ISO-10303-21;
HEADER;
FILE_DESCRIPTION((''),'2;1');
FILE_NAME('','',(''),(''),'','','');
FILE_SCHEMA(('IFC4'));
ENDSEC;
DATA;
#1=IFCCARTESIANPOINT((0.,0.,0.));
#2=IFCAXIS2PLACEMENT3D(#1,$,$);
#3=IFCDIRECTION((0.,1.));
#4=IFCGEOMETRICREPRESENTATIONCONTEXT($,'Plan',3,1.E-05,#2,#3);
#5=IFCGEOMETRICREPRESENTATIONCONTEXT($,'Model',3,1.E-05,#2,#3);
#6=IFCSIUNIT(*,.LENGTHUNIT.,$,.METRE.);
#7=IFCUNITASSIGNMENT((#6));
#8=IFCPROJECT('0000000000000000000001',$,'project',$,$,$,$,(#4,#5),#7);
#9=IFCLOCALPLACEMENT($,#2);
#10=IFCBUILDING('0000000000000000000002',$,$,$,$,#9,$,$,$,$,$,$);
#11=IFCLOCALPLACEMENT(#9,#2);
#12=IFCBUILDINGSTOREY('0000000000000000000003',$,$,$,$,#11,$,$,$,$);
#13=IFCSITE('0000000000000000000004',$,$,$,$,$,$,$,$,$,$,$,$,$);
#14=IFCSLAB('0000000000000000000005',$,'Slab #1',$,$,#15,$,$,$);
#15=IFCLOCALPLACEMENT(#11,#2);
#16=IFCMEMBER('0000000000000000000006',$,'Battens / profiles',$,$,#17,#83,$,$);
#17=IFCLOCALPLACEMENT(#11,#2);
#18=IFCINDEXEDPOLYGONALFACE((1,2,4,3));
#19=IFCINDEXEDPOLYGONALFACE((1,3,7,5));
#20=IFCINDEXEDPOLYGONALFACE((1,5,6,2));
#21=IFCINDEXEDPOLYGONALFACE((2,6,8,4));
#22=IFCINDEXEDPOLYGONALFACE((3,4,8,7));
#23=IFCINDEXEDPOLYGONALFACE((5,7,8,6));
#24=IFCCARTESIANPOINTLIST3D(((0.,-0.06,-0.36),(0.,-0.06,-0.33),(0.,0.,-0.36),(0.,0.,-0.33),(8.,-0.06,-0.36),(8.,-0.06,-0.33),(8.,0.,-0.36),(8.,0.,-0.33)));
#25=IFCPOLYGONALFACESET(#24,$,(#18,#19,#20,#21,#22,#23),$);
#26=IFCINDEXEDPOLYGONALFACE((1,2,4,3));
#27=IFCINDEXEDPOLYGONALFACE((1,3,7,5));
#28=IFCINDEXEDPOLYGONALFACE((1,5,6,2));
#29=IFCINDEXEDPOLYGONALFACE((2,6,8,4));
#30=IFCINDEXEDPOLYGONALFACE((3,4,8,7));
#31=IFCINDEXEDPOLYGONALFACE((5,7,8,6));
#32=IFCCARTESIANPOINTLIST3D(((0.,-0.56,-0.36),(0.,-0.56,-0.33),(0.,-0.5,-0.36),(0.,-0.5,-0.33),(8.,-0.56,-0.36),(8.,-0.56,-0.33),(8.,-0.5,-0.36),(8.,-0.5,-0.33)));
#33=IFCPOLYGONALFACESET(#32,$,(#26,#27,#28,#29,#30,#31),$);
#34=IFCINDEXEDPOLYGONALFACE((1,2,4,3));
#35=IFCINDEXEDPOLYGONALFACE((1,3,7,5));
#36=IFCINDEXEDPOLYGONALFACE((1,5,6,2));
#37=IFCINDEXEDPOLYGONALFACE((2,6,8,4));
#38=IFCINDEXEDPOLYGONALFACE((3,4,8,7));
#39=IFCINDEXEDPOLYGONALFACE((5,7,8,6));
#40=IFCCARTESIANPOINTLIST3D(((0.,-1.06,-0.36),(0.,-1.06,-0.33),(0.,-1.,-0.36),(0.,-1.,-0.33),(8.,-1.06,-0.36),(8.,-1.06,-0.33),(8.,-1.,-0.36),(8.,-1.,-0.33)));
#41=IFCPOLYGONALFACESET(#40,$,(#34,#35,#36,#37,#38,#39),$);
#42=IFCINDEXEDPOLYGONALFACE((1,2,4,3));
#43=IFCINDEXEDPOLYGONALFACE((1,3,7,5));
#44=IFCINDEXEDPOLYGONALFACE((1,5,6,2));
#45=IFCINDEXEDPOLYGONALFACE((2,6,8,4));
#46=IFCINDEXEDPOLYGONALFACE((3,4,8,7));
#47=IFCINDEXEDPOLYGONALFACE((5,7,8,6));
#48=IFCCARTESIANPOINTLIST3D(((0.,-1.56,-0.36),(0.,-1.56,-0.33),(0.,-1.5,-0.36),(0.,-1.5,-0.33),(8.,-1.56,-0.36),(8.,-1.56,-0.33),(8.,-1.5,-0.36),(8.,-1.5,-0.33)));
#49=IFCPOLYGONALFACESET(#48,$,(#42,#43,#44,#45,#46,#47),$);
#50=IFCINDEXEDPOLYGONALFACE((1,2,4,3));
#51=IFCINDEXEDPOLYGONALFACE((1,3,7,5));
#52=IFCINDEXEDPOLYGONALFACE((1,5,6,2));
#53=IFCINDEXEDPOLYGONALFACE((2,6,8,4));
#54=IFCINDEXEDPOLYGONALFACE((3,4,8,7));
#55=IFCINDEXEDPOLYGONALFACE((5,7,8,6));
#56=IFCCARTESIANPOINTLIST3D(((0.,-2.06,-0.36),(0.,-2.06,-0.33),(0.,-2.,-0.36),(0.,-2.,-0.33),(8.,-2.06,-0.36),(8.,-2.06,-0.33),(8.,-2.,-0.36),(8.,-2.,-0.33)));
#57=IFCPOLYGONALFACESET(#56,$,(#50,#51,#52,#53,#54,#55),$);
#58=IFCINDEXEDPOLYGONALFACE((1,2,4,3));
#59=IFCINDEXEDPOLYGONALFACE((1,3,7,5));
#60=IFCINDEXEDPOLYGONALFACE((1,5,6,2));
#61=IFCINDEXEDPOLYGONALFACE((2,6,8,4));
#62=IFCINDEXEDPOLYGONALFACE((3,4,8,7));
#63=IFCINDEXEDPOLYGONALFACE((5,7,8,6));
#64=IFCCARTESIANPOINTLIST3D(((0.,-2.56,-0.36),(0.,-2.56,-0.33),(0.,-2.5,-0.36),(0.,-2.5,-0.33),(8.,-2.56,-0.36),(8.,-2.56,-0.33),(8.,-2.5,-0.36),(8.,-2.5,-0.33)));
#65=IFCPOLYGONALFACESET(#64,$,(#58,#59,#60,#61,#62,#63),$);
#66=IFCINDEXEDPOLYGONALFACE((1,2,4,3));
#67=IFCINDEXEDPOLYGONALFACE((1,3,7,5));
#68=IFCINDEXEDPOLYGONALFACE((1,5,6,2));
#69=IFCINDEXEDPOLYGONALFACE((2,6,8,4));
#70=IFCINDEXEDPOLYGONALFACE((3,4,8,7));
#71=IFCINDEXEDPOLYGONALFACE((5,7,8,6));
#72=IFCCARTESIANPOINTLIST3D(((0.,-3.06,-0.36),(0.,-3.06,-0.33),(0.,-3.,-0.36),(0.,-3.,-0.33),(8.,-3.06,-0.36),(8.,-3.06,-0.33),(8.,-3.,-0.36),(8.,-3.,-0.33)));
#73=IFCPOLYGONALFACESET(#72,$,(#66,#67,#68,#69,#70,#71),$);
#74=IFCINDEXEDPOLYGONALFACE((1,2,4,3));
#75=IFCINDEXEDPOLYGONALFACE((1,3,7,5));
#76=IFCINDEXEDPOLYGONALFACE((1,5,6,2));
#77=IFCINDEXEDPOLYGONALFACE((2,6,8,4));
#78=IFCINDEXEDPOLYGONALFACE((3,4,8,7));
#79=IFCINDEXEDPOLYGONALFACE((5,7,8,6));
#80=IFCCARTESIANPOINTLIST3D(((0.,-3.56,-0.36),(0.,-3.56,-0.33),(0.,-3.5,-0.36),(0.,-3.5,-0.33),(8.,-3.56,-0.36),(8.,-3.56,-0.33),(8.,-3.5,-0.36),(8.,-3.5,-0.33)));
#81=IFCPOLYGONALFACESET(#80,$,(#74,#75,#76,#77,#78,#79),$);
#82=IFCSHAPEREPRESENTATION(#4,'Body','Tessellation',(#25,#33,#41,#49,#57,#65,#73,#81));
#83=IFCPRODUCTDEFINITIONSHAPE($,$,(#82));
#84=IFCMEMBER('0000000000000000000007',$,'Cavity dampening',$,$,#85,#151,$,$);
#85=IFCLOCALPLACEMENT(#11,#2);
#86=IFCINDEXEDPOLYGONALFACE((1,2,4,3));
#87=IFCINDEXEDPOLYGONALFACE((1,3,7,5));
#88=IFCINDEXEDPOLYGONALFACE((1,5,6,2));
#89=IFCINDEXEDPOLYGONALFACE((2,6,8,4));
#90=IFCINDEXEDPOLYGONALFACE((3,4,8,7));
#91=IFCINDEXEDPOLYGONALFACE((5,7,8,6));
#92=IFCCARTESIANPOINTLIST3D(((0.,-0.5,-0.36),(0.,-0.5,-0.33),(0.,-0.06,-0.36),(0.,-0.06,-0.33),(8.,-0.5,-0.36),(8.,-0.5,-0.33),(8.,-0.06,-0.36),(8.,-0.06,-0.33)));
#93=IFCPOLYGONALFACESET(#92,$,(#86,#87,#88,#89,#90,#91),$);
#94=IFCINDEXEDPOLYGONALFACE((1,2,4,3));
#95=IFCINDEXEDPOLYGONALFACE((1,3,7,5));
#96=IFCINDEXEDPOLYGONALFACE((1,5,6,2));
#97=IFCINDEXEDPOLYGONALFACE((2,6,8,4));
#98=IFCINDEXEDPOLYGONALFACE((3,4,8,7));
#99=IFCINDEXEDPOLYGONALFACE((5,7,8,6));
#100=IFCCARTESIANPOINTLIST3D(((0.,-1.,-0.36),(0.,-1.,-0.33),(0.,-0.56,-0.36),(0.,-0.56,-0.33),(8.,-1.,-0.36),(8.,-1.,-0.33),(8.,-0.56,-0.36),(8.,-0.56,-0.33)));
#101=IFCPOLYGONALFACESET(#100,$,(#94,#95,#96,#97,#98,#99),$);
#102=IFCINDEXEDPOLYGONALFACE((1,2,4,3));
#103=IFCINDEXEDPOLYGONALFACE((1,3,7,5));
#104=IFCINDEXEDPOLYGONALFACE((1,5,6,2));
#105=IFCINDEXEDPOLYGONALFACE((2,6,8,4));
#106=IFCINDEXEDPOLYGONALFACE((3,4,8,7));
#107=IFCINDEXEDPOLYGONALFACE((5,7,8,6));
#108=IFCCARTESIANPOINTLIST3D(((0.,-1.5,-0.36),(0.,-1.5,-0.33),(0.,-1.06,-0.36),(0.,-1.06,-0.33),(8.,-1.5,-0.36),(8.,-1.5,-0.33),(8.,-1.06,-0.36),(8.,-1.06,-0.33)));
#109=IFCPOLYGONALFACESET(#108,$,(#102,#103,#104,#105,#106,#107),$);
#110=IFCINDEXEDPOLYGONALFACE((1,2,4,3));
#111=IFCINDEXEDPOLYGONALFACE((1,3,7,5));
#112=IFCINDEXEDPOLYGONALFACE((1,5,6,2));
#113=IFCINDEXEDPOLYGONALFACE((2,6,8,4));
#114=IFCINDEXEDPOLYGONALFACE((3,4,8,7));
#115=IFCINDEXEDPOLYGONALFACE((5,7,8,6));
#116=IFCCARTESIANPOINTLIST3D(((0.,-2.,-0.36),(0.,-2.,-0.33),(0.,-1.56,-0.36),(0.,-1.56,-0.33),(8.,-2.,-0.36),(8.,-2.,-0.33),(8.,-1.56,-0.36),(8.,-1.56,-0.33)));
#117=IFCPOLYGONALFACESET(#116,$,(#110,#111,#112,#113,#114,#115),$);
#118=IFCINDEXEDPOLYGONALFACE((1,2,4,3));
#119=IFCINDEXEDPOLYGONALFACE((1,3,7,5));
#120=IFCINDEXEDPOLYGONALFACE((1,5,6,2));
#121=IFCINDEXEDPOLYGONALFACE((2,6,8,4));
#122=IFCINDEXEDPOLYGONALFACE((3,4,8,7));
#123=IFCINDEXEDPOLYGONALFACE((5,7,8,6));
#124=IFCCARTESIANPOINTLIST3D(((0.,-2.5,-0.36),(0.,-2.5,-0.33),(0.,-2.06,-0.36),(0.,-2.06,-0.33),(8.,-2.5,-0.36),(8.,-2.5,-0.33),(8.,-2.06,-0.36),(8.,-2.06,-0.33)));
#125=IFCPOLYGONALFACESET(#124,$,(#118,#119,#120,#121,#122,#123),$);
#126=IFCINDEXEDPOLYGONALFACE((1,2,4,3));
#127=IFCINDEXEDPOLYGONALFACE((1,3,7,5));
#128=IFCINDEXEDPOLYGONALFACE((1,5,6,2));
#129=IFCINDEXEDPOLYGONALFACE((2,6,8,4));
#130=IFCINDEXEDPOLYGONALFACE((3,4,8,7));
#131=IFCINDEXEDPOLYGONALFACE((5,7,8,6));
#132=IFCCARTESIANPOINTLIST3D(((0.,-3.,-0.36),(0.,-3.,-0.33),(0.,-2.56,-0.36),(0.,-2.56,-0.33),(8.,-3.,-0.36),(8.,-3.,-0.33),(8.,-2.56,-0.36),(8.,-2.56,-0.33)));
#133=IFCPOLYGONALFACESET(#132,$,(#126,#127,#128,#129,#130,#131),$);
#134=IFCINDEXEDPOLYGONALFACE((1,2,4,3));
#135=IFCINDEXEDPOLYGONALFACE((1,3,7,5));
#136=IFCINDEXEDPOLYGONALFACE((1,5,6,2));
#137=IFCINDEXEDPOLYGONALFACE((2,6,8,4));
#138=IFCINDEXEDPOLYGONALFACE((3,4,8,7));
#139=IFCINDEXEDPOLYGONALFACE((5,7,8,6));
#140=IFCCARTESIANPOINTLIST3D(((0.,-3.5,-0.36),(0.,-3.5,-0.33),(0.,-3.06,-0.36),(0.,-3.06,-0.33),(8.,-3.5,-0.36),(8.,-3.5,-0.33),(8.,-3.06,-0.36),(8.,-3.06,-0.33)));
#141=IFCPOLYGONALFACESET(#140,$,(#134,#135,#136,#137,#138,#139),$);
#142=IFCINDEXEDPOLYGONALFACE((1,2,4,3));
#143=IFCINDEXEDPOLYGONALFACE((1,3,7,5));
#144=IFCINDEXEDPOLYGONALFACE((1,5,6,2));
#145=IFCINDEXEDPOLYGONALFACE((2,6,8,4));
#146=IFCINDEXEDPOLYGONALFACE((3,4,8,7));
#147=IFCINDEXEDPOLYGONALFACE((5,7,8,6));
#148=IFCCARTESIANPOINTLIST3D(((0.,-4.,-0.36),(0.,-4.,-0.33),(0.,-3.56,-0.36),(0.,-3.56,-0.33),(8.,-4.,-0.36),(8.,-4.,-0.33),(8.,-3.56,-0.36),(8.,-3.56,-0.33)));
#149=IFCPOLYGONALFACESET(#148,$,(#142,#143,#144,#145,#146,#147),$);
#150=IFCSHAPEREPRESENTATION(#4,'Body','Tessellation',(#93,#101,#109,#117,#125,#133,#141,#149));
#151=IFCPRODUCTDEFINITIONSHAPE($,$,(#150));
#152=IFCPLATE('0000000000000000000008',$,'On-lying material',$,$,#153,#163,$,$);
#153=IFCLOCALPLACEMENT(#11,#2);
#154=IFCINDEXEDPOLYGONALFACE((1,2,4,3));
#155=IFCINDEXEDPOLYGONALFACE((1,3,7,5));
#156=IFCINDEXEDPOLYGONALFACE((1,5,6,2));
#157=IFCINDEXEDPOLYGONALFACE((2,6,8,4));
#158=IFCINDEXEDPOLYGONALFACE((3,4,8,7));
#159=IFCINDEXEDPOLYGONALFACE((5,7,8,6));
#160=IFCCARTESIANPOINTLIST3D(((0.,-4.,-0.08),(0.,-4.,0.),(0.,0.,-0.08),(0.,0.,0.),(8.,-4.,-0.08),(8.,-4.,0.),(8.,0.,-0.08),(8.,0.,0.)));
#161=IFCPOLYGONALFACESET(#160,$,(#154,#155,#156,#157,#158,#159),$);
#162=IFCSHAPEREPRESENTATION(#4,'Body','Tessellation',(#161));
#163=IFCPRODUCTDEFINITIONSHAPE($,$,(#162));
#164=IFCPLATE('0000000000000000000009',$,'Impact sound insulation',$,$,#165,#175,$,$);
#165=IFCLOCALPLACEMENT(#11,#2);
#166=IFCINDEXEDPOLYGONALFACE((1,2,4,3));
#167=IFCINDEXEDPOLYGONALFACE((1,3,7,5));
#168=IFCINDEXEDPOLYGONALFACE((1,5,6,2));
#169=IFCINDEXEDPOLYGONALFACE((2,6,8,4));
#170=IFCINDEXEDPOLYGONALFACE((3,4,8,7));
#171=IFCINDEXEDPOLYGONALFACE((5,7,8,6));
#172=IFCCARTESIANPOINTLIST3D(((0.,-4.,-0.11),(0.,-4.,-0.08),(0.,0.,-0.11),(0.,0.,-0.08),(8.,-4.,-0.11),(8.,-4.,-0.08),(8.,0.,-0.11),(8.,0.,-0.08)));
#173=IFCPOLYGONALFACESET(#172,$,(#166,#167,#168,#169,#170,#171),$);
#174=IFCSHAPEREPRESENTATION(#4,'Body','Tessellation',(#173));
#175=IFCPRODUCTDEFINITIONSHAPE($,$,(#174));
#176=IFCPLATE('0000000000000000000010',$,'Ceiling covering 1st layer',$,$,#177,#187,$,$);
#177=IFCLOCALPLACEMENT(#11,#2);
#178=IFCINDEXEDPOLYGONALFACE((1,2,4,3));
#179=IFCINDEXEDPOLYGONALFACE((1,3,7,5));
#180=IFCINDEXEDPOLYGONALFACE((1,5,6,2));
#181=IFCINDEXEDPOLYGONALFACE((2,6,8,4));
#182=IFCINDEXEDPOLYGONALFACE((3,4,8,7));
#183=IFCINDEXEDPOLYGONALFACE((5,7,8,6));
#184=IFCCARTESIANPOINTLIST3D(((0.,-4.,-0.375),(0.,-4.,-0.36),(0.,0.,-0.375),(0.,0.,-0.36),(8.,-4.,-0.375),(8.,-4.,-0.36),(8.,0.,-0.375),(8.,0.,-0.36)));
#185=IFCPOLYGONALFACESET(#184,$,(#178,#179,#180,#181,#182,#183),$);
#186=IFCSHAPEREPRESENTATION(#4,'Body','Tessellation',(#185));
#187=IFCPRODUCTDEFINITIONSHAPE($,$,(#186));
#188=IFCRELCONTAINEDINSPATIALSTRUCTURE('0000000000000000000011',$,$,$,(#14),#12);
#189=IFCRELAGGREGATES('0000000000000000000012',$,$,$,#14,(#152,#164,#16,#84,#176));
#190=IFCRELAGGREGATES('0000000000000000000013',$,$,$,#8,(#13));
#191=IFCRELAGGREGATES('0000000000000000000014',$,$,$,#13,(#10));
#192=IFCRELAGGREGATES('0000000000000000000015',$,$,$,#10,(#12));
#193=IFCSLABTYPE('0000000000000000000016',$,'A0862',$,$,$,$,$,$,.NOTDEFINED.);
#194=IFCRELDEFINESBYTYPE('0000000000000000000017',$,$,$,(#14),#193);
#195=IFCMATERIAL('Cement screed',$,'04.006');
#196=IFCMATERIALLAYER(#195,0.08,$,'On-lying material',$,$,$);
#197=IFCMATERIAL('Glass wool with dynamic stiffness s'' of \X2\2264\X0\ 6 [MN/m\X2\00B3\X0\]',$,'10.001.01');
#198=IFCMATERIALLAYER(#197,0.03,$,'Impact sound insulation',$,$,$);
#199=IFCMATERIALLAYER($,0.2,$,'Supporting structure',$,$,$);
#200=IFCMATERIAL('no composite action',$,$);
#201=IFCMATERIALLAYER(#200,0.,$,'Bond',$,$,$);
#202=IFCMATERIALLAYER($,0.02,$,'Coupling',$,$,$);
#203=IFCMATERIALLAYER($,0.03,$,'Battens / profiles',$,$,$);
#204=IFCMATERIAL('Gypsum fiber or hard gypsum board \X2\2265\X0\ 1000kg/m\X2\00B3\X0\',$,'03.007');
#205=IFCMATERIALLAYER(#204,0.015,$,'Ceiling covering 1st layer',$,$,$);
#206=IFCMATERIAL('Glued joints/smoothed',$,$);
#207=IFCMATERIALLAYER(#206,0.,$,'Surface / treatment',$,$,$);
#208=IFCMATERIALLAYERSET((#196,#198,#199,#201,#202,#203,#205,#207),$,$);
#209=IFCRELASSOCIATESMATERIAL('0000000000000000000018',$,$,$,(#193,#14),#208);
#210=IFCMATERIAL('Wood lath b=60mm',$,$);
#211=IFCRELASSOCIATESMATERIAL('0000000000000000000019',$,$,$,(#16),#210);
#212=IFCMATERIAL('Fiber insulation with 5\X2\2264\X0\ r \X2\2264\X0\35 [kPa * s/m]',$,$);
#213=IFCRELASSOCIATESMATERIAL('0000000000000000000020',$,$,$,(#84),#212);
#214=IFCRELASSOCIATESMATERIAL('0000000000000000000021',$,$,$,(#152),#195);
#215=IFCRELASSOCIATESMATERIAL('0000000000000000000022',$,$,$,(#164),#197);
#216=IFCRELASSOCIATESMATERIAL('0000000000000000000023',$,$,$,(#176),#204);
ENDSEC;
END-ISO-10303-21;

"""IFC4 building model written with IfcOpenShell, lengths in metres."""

from ifc_helpers import new_model, si_unit, direction, frame, frame_2d, origin, origin_with_axes, place, context, project, spatial, rectangle, extrude, material, layer, layer_set, type_object, element, aggregate, save


model = new_model("IFC4")

# Units and contexts
plan_context = context("Plan", 3, precision=1e-05, world=origin(), true_north=direction((0.0, 1.0)))
model_context = context("Model", 3, precision=1e-05, world=origin(), true_north=direction((0.0, 1.0)))
ifc_project = project(units=[si_unit("LENGTHUNIT", "METRE")], contexts=[plan_context, model_context])

# Site, building, storey
site = spatial("IfcSite", under=ifc_project)
building_placement = place(None, origin())
building = spatial("IfcBuilding", under=site, at=building_placement)
storey_placement = place(building_placement, origin())
storey = spatial("IfcBuildingStorey", under=building, at=storey_placement)

# Slab, members, plates
ifc_material_1 = material(Name="Cement screed", Category="04.006")
ifc_layer_1 = layer(ifc_material_1, 0.08, Name="On-lying material")
ifc_material_2 = material(Name="Glass wool with dynamic stiffness s' of ≤ 6 [MN/m³]", Category="10.001.01")
ifc_layer_2 = layer(ifc_material_2, 0.03, Name="Impact sound insulation")
ifc_layer_3 = layer(None, 0.2, Name="Supporting structure")
ifc_material_3 = material(Name="no composite action")
ifc_layer_4 = layer(ifc_material_3, 0.0, Name="Bond")
ifc_layer_5 = layer(None, 0.02, Name="Coupling")
ifc_layer_6 = layer(None, 0.03, Name="Battens / profiles")
ifc_material_4 = material(Name="Gypsum fiber or hard gypsum board ≥ 1000kg/m³", Category="03.007")
ifc_layer_7 = layer(ifc_material_4, 0.015, Name="Ceiling covering 1st layer")
ifc_material_5 = material(Name="Glued joints/smoothed")
ifc_layer_8 = layer(ifc_material_5, 0.0, Name="Surface / treatment")
ifc_layer_set = layer_set([ifc_layer_1, ifc_layer_2, ifc_layer_3, ifc_layer_4, ifc_layer_5, ifc_layer_6, ifc_layer_7, ifc_layer_8])
slab_type = type_object("IfcSlabType", Name="A0862", PredefinedType="NOTDEFINED", material=ifc_layer_set)
slab_placement = place(None, frame((0.0, 0.0, 0.0), z_axis=(0.0, 0.0, -1.0), x_axis=(1.0, 0.0, 0.0)))
slab = element("IfcSlab", 1, at=slab_placement, inside=storey, type_object=slab_type, material=ifc_layer_set, Name="Slab #1")
ifc_material_6 = material(Name="Wood lath b=60mm")
member_1_placement = place(slab_placement, origin())
member_1 = element("IfcMember", 2, at=member_1_placement, material=ifc_material_6, Name="Battens / profiles", context=plan_context, shape_type="SweptSolid", body=[
    extrude(rectangle(XDim=0.06, YDim=0.03, at=frame_2d((0.03, 0.015), x_axis=(1.0, 0.0))), frame((0.0, 0.0, 0.33), z_axis=(1.0, 0.0, 0.0), x_axis=(0.0, 1.0, 0.0)), (0.0, 0.0, 1.0), 8.0),
    extrude(rectangle(XDim=0.06, YDim=0.03, at=frame_2d((0.03, 0.015), x_axis=(1.0, 0.0))), frame((0.0, 0.5, 0.33), z_axis=(1.0, 0.0, 0.0), x_axis=(0.0, 1.0, 0.0)), (0.0, 0.0, 1.0), 8.0),
    extrude(rectangle(XDim=0.06, YDim=0.03, at=frame_2d((0.03, 0.015), x_axis=(1.0, 0.0))), frame((0.0, 1.0, 0.33), z_axis=(1.0, 0.0, 0.0), x_axis=(0.0, 1.0, 0.0)), (0.0, 0.0, 1.0), 8.0),
    extrude(rectangle(XDim=0.06, YDim=0.03, at=frame_2d((0.03, 0.015), x_axis=(1.0, 0.0))), frame((0.0, 1.5, 0.33), z_axis=(1.0, 0.0, 0.0), x_axis=(0.0, 1.0, 0.0)), (0.0, 0.0, 1.0), 8.0),
    extrude(rectangle(XDim=0.06, YDim=0.03, at=frame_2d((0.03, 0.015), x_axis=(1.0, 0.0))), frame((0.0, 2.0, 0.33), z_axis=(1.0, 0.0, 0.0), x_axis=(0.0, 1.0, 0.0)), (0.0, 0.0, 1.0), 8.0),
    extrude(rectangle(XDim=0.06, YDim=0.03, at=frame_2d((0.03, 0.015), x_axis=(1.0, 0.0))), frame((0.0, 2.5, 0.33), z_axis=(1.0, 0.0, 0.0), x_axis=(0.0, 1.0, 0.0)), (0.0, 0.0, 1.0), 8.0),
    extrude(rectangle(XDim=0.06, YDim=0.03, at=frame_2d((0.03, 0.015), x_axis=(1.0, 0.0))), frame((0.0, 3.0, 0.33), z_axis=(1.0, 0.0, 0.0), x_axis=(0.0, 1.0, 0.0)), (0.0, 0.0, 1.0), 8.0),
    extrude(rectangle(XDim=0.06, YDim=0.03, at=frame_2d((0.03, 0.015), x_axis=(1.0, 0.0))), frame((0.0, 3.5, 0.33), z_axis=(1.0, 0.0, 0.0), x_axis=(0.0, 1.0, 0.0)), (0.0, 0.0, 1.0), 8.0),
])
ifc_material_7 = material(Name="Fiber insulation with 5≤ r ≤35 [kPa * s/m]")
member_2_placement = place(slab_placement, origin())
member_2 = element("IfcMember", 3, at=member_2_placement, material=ifc_material_7, Name="Cavity dampening", context=plan_context, shape_type="SweptSolid", body=[
    extrude(rectangle(XDim=0.44, YDim=0.03, at=frame_2d((0.22, 0.015), x_axis=(1.0, 0.0))), frame((0.0, 0.06, 0.33), z_axis=(1.0, 0.0, 0.0), x_axis=(0.0, 1.0, 0.0)), (0.0, 0.0, 1.0), 8.0),
    extrude(rectangle(XDim=0.44, YDim=0.03, at=frame_2d((0.22, 0.015), x_axis=(1.0, 0.0))), frame((0.0, 0.56, 0.33), z_axis=(1.0, 0.0, 0.0), x_axis=(0.0, 1.0, 0.0)), (0.0, 0.0, 1.0), 8.0),
    extrude(rectangle(XDim=0.44, YDim=0.03, at=frame_2d((0.22, 0.015), x_axis=(1.0, 0.0))), frame((0.0, 1.06, 0.33), z_axis=(1.0, 0.0, 0.0), x_axis=(0.0, 1.0, 0.0)), (0.0, 0.0, 1.0), 8.0),
    extrude(rectangle(XDim=0.44, YDim=0.03, at=frame_2d((0.22, 0.015), x_axis=(1.0, 0.0))), frame((0.0, 1.56, 0.33), z_axis=(1.0, 0.0, 0.0), x_axis=(0.0, 1.0, 0.0)), (0.0, 0.0, 1.0), 8.0),
    extrude(rectangle(XDim=0.44, YDim=0.03, at=frame_2d((0.22, 0.015), x_axis=(1.0, 0.0))), frame((0.0, 2.06, 0.33), z_axis=(1.0, 0.0, 0.0), x_axis=(0.0, 1.0, 0.0)), (0.0, 0.0, 1.0), 8.0),
    extrude(rectangle(XDim=0.44, YDim=0.03, at=frame_2d((0.22, 0.015), x_axis=(1.0, 0.0))), frame((0.0, 2.56, 0.33), z_axis=(1.0, 0.0, 0.0), x_axis=(0.0, 1.0, 0.0)), (0.0, 0.0, 1.0), 8.0),
    extrude(rectangle(XDim=0.44, YDim=0.03, at=frame_2d((0.22, 0.015), x_axis=(1.0, 0.0))), frame((0.0, 3.06, 0.33), z_axis=(1.0, 0.0, 0.0), x_axis=(0.0, 1.0, 0.0)), (0.0, 0.0, 1.0), 8.0),
    extrude(rectangle(XDim=0.44, YDim=0.03, at=frame_2d((0.22, 0.015), x_axis=(1.0, 0.0))), frame((0.0, 3.56, 0.33), z_axis=(1.0, 0.0, 0.0), x_axis=(0.0, 1.0, 0.0)), (0.0, 0.0, 1.0), 8.0),
])
plate_1_placement = place(slab_placement, origin())
plate_1 = element("IfcPlate", 4, at=plate_1_placement, material=ifc_material_1, Name="On-lying material", context=plan_context, shape_type="SweptSolid", body=[
    extrude(rectangle(XDim=8.0, YDim=4.0, at=frame_2d((4.0, 2.0), x_axis=(1.0, 0.0))), origin_with_axes(), (0.0, 0.0, 1.0), 0.08),
])
plate_2_placement = place(slab_placement, origin())
plate_2 = element("IfcPlate", 5, at=plate_2_placement, material=ifc_material_2, Name="Impact sound insulation", context=plan_context, shape_type="SweptSolid", body=[
    extrude(rectangle(XDim=8.0, YDim=4.0, at=frame_2d((4.0, 2.0), x_axis=(1.0, 0.0))), frame((0.0, 0.0, 0.08), z_axis=(0.0, 0.0, 1.0), x_axis=(1.0, 0.0, 0.0)), (0.0, 0.0, 1.0), 0.03),
])
plate_3_placement = place(slab_placement, origin())
plate_3 = element("IfcPlate", 6, at=plate_3_placement, material=ifc_material_4, Name="Ceiling covering 1st layer", context=plan_context, shape_type="SweptSolid", body=[
    extrude(rectangle(XDim=8.0, YDim=4.0, at=frame_2d((4.0, 2.0), x_axis=(1.0, 0.0))), frame((0.0, 0.0, 0.36), z_axis=(0.0, 0.0, 1.0), x_axis=(1.0, 0.0, 0.0)), (0.0, 0.0, 1.0), 0.015),
])
aggregate(slab, [plate_1, plate_2, member_1, member_2, plate_3])

save(model, "model.ifc")
